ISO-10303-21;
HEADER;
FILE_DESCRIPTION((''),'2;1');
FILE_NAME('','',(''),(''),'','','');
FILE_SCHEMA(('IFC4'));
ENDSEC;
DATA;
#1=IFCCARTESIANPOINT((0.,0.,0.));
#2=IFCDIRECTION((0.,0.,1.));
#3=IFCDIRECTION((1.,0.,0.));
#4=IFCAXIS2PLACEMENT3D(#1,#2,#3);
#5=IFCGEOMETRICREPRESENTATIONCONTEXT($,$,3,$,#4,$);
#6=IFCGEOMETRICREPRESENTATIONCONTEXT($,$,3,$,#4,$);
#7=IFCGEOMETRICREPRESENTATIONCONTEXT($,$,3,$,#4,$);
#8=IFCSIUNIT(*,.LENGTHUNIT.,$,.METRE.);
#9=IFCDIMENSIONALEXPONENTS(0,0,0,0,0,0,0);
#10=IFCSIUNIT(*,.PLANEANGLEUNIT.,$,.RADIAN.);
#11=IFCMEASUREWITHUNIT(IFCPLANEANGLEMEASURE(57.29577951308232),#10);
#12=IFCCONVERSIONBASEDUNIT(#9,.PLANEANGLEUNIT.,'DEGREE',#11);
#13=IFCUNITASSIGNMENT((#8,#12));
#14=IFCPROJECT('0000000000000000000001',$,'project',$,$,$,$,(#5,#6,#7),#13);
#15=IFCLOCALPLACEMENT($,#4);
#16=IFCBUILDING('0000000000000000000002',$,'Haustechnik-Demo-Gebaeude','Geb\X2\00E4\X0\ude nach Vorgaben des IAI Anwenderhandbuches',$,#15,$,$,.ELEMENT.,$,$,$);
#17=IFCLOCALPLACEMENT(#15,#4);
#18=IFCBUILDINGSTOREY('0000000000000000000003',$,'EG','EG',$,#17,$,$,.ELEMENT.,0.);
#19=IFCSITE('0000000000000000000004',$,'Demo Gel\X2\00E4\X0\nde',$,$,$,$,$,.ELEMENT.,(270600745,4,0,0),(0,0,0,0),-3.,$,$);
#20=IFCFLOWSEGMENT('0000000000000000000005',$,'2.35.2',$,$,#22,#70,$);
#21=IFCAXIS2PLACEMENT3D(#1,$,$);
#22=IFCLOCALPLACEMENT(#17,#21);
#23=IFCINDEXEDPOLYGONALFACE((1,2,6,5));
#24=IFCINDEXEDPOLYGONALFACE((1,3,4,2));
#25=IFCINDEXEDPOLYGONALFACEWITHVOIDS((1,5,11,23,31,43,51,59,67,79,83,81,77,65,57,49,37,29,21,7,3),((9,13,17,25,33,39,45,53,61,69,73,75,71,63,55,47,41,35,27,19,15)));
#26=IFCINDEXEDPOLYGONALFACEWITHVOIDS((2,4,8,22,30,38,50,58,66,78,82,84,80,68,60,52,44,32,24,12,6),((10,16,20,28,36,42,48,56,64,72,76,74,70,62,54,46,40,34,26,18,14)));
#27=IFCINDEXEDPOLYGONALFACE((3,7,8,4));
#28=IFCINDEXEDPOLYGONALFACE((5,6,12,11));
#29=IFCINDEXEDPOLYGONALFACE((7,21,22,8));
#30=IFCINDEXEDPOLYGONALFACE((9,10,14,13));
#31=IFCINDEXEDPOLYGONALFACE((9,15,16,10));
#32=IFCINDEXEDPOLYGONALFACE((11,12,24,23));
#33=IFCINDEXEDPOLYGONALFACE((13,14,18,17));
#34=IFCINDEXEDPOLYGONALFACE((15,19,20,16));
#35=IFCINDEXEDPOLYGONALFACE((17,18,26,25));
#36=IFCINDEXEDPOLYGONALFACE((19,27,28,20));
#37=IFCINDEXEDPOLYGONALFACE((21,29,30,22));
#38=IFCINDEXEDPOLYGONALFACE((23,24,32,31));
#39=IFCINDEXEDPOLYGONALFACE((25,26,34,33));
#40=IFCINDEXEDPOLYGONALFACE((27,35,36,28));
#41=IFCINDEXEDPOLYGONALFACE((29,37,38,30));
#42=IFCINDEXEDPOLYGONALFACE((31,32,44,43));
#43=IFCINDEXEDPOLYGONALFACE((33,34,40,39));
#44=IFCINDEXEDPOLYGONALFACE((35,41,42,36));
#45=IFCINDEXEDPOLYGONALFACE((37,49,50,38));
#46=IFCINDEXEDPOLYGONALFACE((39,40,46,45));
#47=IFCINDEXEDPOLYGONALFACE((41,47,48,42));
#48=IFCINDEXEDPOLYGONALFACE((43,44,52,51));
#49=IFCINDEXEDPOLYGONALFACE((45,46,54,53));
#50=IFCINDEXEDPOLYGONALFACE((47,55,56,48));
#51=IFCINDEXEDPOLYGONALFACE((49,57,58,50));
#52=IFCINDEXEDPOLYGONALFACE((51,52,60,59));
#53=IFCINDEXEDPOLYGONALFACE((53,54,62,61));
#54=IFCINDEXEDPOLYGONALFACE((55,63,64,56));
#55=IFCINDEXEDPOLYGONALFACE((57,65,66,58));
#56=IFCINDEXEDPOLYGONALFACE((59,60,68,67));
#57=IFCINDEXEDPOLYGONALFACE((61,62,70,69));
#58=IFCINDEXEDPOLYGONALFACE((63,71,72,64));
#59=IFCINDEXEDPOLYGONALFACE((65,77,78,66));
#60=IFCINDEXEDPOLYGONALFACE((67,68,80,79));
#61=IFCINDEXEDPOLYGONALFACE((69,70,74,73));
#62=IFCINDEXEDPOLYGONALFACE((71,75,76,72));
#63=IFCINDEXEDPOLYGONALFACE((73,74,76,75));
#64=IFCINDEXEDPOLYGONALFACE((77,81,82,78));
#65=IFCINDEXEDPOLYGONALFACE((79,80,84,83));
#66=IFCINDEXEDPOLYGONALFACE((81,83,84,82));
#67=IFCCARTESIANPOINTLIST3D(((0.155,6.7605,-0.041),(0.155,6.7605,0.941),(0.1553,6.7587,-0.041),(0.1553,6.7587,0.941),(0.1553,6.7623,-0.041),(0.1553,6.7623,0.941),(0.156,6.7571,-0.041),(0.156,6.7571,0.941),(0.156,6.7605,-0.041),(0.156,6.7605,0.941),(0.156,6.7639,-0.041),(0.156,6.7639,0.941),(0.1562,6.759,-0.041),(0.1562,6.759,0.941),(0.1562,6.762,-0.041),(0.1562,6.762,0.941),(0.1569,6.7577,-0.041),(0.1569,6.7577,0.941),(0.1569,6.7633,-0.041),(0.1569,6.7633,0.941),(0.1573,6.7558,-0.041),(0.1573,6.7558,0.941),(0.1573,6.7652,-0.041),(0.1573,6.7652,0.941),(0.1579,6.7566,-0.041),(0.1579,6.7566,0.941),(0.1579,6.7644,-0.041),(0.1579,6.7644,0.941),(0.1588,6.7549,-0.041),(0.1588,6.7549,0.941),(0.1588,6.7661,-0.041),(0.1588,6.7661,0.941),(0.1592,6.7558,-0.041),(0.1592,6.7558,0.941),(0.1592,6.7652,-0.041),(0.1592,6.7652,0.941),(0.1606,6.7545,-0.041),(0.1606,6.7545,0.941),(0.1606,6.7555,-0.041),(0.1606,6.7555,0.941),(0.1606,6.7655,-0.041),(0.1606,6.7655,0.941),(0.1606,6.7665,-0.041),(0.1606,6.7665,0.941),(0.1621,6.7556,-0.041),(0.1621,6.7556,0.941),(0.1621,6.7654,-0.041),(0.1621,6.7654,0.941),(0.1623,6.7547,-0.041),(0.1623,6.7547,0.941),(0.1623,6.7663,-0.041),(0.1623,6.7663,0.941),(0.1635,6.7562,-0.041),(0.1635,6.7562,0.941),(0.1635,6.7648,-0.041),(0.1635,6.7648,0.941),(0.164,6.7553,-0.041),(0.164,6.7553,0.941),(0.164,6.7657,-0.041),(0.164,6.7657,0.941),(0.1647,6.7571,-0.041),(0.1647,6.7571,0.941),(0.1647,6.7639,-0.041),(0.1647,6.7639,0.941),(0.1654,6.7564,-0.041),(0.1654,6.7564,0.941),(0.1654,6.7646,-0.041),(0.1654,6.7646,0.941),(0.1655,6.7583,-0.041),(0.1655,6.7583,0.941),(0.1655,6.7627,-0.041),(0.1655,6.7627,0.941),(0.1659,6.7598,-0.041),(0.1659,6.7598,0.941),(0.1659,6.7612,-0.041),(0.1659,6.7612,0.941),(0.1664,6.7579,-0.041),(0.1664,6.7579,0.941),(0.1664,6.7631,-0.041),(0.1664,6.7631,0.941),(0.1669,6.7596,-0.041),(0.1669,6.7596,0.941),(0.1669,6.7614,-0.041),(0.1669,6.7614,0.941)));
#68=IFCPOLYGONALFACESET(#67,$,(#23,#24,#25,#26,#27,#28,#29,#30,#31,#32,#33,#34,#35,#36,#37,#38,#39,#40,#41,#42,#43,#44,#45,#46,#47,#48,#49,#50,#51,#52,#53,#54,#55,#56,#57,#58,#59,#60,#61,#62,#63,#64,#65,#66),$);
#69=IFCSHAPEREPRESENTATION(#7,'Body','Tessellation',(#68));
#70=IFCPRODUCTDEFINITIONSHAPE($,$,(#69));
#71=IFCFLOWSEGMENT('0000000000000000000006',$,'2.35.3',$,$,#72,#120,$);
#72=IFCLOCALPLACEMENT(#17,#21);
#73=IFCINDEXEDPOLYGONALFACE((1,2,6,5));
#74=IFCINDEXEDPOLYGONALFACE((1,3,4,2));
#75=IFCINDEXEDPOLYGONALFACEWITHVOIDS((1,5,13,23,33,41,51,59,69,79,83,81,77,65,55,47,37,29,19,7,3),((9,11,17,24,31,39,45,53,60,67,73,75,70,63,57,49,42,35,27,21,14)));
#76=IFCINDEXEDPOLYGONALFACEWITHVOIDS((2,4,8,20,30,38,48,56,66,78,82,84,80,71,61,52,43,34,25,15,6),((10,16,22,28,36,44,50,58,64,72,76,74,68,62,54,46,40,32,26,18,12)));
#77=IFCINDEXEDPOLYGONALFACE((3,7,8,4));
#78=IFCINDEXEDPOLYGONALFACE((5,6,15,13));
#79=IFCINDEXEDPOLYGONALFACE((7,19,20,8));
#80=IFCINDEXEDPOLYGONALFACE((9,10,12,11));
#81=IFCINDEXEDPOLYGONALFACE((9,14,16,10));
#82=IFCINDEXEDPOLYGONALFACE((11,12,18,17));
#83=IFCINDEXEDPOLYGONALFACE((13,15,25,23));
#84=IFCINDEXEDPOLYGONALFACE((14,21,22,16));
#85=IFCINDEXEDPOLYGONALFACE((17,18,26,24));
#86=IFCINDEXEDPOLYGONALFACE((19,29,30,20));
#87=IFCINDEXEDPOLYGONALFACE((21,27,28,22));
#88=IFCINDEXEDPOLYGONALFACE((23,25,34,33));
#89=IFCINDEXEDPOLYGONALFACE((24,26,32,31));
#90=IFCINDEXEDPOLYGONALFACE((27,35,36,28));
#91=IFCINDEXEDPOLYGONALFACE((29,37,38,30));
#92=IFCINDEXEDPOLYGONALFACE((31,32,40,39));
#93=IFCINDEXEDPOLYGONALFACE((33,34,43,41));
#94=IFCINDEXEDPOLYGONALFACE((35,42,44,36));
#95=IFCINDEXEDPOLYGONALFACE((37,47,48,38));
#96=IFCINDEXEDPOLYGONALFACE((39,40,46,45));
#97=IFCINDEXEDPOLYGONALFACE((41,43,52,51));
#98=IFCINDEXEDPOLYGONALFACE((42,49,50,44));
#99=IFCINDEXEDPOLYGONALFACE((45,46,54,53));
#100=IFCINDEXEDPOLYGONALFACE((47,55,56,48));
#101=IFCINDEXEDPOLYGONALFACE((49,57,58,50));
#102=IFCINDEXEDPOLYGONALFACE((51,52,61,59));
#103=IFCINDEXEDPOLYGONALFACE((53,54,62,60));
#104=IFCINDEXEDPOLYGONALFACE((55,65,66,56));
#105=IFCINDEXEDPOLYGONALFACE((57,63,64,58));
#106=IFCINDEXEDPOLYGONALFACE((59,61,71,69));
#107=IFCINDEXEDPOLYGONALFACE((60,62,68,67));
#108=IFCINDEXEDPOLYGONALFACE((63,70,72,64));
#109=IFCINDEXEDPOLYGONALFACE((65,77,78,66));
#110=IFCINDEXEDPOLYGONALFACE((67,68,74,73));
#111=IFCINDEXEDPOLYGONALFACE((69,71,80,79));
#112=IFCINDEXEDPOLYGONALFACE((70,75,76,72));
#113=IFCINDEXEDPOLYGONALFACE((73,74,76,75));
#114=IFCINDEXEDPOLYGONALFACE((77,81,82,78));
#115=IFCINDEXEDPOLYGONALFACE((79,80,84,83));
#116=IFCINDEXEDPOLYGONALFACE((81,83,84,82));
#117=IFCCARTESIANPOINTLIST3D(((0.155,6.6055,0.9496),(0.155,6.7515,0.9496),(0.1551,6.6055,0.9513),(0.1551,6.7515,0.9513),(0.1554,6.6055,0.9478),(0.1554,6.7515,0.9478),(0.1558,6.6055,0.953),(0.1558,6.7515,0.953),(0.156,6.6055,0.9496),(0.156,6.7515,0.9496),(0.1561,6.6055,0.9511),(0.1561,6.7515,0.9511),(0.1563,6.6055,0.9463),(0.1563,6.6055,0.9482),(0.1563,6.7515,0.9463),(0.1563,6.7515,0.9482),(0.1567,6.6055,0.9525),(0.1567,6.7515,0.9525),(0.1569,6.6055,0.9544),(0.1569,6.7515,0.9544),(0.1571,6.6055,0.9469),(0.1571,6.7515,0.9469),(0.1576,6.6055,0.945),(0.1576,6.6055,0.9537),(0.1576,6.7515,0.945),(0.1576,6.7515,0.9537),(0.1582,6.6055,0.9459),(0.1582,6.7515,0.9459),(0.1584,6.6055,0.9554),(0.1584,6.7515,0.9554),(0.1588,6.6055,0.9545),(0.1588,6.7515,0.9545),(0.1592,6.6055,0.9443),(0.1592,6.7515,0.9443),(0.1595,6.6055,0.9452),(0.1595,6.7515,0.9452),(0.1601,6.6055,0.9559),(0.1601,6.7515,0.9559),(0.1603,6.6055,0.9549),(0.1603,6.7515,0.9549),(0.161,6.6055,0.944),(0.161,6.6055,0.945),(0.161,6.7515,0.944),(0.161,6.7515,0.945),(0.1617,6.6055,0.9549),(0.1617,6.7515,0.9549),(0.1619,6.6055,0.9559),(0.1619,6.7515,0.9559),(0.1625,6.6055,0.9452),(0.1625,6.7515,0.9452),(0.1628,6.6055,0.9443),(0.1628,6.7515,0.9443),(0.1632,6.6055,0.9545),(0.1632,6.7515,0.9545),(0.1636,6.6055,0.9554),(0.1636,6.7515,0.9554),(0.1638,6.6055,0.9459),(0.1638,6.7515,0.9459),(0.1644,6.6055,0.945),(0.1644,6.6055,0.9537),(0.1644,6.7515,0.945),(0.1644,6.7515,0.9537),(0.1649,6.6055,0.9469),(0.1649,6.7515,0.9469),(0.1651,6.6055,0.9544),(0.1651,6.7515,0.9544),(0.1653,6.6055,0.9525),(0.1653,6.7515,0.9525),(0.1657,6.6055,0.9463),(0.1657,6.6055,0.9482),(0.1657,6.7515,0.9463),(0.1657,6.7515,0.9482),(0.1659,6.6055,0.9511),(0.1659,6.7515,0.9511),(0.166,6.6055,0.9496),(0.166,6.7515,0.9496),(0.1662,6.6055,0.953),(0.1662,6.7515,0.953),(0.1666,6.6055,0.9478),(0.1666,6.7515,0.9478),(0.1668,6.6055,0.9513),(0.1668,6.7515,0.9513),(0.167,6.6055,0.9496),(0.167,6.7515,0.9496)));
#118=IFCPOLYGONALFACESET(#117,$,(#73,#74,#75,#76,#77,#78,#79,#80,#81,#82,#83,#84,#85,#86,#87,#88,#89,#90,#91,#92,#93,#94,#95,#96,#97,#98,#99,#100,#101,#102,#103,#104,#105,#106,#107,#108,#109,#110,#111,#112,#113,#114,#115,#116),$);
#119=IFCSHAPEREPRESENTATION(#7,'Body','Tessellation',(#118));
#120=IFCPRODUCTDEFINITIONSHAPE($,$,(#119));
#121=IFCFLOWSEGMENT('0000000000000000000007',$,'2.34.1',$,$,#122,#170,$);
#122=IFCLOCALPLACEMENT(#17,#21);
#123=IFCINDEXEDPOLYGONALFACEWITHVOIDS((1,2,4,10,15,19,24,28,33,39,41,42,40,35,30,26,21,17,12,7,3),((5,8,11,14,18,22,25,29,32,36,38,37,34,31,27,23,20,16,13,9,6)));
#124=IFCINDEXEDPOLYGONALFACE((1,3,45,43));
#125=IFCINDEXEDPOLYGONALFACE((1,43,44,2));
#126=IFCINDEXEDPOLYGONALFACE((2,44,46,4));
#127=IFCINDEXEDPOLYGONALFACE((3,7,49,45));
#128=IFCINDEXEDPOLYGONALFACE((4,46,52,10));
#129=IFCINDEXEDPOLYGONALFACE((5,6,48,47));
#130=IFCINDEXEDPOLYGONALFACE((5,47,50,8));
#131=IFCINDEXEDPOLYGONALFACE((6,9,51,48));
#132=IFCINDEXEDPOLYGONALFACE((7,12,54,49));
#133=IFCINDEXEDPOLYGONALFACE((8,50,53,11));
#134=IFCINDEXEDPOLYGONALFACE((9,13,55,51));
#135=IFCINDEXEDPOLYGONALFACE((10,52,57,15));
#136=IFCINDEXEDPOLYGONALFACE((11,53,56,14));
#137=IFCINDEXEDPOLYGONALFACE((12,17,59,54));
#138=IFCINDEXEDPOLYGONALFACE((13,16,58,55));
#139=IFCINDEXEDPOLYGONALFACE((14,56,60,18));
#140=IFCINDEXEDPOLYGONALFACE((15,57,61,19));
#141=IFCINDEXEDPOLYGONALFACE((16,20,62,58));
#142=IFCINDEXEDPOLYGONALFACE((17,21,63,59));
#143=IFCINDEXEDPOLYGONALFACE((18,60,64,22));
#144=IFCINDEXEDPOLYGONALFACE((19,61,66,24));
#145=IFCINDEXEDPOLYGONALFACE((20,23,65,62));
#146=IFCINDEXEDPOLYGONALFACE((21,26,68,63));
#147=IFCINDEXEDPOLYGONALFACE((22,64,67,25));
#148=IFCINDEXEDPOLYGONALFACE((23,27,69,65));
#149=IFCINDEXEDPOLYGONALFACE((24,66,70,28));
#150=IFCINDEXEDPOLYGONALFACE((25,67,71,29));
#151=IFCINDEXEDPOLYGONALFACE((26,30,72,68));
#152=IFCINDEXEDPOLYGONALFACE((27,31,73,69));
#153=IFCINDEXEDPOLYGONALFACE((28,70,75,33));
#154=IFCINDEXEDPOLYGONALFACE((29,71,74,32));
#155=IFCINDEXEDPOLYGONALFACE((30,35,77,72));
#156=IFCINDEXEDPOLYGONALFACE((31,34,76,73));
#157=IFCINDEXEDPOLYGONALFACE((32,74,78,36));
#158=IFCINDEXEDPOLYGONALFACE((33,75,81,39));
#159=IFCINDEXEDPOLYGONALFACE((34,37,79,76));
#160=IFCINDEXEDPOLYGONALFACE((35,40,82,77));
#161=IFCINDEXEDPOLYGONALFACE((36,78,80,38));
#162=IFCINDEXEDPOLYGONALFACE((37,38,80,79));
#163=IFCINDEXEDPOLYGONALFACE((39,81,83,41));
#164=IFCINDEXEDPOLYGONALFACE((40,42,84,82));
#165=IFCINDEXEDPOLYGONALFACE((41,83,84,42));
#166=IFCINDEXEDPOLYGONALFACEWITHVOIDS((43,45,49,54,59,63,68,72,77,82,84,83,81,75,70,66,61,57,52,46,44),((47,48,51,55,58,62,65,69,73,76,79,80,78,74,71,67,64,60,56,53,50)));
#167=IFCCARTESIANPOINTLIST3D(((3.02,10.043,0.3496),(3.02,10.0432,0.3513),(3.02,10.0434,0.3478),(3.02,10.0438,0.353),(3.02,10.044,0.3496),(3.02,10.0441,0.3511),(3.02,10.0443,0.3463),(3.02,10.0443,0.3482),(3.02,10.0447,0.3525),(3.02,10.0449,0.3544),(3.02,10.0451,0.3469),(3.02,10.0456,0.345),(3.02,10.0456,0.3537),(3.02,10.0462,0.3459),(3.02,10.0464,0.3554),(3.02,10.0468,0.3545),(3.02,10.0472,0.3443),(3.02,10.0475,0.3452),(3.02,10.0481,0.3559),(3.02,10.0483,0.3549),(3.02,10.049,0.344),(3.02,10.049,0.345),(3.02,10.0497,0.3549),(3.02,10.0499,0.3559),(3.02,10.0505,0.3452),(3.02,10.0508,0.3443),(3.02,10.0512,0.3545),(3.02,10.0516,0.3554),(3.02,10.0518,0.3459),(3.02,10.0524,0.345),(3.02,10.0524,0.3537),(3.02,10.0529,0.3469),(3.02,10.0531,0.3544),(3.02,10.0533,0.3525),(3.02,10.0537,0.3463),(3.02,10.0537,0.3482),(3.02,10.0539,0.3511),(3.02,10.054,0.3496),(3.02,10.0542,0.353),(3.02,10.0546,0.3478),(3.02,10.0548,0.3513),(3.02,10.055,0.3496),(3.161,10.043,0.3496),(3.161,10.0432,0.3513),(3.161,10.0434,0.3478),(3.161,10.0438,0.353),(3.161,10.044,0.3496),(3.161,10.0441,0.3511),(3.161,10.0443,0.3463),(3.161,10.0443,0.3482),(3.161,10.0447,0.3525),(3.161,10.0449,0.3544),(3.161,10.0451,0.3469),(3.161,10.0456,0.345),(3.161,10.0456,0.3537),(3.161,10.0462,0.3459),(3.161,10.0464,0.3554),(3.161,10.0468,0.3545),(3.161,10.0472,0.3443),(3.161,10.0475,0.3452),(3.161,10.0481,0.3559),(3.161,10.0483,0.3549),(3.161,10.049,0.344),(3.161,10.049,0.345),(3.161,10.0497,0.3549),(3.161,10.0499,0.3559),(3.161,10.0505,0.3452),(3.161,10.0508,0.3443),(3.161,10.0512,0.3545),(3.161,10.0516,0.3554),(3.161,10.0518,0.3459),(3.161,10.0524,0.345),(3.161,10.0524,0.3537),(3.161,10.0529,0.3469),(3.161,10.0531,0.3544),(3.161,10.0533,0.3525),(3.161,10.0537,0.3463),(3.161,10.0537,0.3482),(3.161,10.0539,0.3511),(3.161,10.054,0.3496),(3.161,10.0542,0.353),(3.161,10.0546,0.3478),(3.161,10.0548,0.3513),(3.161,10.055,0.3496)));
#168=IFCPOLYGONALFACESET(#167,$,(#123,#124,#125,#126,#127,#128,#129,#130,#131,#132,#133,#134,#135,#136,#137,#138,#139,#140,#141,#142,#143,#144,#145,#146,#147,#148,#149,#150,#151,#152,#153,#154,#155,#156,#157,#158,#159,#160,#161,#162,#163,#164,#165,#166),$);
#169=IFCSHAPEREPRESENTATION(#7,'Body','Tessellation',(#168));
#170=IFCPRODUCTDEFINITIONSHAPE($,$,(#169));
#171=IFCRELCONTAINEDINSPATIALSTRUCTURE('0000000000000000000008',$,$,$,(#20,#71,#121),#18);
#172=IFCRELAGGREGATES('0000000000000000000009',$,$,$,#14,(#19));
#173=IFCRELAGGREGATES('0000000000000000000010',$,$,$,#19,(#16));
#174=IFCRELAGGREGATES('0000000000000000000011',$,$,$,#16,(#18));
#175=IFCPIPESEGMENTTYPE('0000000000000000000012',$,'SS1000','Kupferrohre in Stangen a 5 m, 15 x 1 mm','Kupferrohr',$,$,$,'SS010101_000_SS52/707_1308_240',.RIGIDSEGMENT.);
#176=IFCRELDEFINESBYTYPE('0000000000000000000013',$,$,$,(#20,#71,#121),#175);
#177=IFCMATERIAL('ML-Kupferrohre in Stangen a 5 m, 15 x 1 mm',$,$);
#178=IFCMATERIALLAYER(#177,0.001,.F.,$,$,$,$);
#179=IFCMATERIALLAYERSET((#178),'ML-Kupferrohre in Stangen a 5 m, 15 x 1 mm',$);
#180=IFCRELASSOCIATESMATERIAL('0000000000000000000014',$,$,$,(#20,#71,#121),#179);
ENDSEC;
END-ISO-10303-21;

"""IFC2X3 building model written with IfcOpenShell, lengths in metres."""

from ifc_helpers import new_model, entity, si_unit, converted_unit, frame, origin_with_axes, origin_2d_with_axis, place, context, project, spatial, hollow_circle, extrude, material, layer, layer_set, layer_usage, type_object, element, save


model = new_model("IFC2X3")

# Units and contexts
context_of_model_1 = context(None, 3, world=origin_with_axes())
context_of_model_2 = context(None, 3, world=origin_with_axes())
context_of_model_3 = context(None, 3, world=origin_with_axes())
ifc_project = project(units=[si_unit("LENGTHUNIT", "METRE"), converted_unit("PLANEANGLEUNIT", "DEGREE", entity("IfcPlaneAngleMeasure", 57.29577951308232), si_unit("PLANEANGLEUNIT", "RADIAN"), dimensions=[0, 0, 0, 0, 0, 0, 0])], contexts=[context_of_model_1, context_of_model_2, context_of_model_3])

# Site, building, storey
site = spatial("IfcSite", under=ifc_project, Name="Demo Gelände", CompositionType="ELEMENT", RefLatitude=(270600745, 4, 0, 0), RefLongitude=(0, 0, 0, 0), RefElevation=-3.0)
building_placement = place(None, origin_with_axes())
building = spatial("IfcBuilding", under=site, at=building_placement, Name="Haustechnik-Demo-Gebaeude", Description="Gebäude nach Vorgaben des IAI Anwenderhandbuches", CompositionType="ELEMENT")
storey_placement = place(building_placement, origin_with_axes())
storey = spatial("IfcBuildingStorey", under=building, at=storey_placement, Name="EG", Description="EG", CompositionType="ELEMENT", Elevation=0.0)

# Flow segments
ifc_material_1 = material(Name="ML-Kupferrohre in Stangen a 5 m, 15 x 1 mm")
ifc_layer_1 = layer(ifc_material_1, 0.001, ventilated=False)
ifc_layer_set_1 = layer_set([ifc_layer_1], Name="ML-Kupferrohre in Stangen a 5 m, 15 x 1 mm")
ifc_layer_usage_1 = layer_usage(ifc_layer_set_1, "AXIS2", "POSITIVE", 0.0)
pipe_segment_type_1 = type_object("IfcPipeSegmentType", Name="SS1000", Description="Kupferrohre in Stangen a 5 m, 15 x 1 mm", ApplicableOccurrence="Kupferrohr", ElementType="SS010101_000_SS52/707_1308_240", PredefinedType="RIGIDSEGMENT")
flow_segment_1_placement = place(storey_placement, frame((0.161, 6.7605, -0.041), z_axis=(0.0, 0.0, 1.0), x_axis=(-1.0, 0.0, 0.0)))
element("IfcFlowSegment", 1, at=flow_segment_1_placement, inside=storey, type_object=pipe_segment_type_1, material=ifc_layer_usage_1, Name="2.35.2", context=context_of_model_3, shape_type="SweptSolid", body=[
    extrude(hollow_circle(Radius=0.006, WallThickness=0.001, at=origin_2d_with_axis()), origin_with_axes(), (0.0, 0.0, 1.0), 0.982),
])
flow_segment_2_placement = place(storey_placement, frame((0.161, 6.7515, 0.95), z_axis=(0.0, -1.0, 0.0), x_axis=(0.0, 0.0, -1.0)))
element("IfcFlowSegment", 2, at=flow_segment_2_placement, inside=storey, type_object=pipe_segment_type_1, material=ifc_layer_usage_1, Name="2.35.3", context=context_of_model_3, shape_type="SweptSolid", body=[
    extrude(hollow_circle(Radius=0.006, WallThickness=0.001, at=origin_2d_with_axis()), origin_with_axes(), (0.0, 0.0, 1.0), 0.146),
])
flow_segment_3_placement = place(storey_placement, frame((3.02, 10.049, 0.35), z_axis=(1.0, 0.0, 0.0), x_axis=(0.0, 0.0, -1.0)))
element("IfcFlowSegment", 3, at=flow_segment_3_placement, inside=storey, type_object=pipe_segment_type_1, material=ifc_layer_usage_1, Name="2.34.1", context=context_of_model_3, shape_type="SweptSolid", body=[
    extrude(hollow_circle(Radius=0.006, WallThickness=0.001, at=origin_2d_with_axis()), origin_with_axes(), (0.0, 0.0, 1.0), 0.141),
])

save(model, "model.ifc")
